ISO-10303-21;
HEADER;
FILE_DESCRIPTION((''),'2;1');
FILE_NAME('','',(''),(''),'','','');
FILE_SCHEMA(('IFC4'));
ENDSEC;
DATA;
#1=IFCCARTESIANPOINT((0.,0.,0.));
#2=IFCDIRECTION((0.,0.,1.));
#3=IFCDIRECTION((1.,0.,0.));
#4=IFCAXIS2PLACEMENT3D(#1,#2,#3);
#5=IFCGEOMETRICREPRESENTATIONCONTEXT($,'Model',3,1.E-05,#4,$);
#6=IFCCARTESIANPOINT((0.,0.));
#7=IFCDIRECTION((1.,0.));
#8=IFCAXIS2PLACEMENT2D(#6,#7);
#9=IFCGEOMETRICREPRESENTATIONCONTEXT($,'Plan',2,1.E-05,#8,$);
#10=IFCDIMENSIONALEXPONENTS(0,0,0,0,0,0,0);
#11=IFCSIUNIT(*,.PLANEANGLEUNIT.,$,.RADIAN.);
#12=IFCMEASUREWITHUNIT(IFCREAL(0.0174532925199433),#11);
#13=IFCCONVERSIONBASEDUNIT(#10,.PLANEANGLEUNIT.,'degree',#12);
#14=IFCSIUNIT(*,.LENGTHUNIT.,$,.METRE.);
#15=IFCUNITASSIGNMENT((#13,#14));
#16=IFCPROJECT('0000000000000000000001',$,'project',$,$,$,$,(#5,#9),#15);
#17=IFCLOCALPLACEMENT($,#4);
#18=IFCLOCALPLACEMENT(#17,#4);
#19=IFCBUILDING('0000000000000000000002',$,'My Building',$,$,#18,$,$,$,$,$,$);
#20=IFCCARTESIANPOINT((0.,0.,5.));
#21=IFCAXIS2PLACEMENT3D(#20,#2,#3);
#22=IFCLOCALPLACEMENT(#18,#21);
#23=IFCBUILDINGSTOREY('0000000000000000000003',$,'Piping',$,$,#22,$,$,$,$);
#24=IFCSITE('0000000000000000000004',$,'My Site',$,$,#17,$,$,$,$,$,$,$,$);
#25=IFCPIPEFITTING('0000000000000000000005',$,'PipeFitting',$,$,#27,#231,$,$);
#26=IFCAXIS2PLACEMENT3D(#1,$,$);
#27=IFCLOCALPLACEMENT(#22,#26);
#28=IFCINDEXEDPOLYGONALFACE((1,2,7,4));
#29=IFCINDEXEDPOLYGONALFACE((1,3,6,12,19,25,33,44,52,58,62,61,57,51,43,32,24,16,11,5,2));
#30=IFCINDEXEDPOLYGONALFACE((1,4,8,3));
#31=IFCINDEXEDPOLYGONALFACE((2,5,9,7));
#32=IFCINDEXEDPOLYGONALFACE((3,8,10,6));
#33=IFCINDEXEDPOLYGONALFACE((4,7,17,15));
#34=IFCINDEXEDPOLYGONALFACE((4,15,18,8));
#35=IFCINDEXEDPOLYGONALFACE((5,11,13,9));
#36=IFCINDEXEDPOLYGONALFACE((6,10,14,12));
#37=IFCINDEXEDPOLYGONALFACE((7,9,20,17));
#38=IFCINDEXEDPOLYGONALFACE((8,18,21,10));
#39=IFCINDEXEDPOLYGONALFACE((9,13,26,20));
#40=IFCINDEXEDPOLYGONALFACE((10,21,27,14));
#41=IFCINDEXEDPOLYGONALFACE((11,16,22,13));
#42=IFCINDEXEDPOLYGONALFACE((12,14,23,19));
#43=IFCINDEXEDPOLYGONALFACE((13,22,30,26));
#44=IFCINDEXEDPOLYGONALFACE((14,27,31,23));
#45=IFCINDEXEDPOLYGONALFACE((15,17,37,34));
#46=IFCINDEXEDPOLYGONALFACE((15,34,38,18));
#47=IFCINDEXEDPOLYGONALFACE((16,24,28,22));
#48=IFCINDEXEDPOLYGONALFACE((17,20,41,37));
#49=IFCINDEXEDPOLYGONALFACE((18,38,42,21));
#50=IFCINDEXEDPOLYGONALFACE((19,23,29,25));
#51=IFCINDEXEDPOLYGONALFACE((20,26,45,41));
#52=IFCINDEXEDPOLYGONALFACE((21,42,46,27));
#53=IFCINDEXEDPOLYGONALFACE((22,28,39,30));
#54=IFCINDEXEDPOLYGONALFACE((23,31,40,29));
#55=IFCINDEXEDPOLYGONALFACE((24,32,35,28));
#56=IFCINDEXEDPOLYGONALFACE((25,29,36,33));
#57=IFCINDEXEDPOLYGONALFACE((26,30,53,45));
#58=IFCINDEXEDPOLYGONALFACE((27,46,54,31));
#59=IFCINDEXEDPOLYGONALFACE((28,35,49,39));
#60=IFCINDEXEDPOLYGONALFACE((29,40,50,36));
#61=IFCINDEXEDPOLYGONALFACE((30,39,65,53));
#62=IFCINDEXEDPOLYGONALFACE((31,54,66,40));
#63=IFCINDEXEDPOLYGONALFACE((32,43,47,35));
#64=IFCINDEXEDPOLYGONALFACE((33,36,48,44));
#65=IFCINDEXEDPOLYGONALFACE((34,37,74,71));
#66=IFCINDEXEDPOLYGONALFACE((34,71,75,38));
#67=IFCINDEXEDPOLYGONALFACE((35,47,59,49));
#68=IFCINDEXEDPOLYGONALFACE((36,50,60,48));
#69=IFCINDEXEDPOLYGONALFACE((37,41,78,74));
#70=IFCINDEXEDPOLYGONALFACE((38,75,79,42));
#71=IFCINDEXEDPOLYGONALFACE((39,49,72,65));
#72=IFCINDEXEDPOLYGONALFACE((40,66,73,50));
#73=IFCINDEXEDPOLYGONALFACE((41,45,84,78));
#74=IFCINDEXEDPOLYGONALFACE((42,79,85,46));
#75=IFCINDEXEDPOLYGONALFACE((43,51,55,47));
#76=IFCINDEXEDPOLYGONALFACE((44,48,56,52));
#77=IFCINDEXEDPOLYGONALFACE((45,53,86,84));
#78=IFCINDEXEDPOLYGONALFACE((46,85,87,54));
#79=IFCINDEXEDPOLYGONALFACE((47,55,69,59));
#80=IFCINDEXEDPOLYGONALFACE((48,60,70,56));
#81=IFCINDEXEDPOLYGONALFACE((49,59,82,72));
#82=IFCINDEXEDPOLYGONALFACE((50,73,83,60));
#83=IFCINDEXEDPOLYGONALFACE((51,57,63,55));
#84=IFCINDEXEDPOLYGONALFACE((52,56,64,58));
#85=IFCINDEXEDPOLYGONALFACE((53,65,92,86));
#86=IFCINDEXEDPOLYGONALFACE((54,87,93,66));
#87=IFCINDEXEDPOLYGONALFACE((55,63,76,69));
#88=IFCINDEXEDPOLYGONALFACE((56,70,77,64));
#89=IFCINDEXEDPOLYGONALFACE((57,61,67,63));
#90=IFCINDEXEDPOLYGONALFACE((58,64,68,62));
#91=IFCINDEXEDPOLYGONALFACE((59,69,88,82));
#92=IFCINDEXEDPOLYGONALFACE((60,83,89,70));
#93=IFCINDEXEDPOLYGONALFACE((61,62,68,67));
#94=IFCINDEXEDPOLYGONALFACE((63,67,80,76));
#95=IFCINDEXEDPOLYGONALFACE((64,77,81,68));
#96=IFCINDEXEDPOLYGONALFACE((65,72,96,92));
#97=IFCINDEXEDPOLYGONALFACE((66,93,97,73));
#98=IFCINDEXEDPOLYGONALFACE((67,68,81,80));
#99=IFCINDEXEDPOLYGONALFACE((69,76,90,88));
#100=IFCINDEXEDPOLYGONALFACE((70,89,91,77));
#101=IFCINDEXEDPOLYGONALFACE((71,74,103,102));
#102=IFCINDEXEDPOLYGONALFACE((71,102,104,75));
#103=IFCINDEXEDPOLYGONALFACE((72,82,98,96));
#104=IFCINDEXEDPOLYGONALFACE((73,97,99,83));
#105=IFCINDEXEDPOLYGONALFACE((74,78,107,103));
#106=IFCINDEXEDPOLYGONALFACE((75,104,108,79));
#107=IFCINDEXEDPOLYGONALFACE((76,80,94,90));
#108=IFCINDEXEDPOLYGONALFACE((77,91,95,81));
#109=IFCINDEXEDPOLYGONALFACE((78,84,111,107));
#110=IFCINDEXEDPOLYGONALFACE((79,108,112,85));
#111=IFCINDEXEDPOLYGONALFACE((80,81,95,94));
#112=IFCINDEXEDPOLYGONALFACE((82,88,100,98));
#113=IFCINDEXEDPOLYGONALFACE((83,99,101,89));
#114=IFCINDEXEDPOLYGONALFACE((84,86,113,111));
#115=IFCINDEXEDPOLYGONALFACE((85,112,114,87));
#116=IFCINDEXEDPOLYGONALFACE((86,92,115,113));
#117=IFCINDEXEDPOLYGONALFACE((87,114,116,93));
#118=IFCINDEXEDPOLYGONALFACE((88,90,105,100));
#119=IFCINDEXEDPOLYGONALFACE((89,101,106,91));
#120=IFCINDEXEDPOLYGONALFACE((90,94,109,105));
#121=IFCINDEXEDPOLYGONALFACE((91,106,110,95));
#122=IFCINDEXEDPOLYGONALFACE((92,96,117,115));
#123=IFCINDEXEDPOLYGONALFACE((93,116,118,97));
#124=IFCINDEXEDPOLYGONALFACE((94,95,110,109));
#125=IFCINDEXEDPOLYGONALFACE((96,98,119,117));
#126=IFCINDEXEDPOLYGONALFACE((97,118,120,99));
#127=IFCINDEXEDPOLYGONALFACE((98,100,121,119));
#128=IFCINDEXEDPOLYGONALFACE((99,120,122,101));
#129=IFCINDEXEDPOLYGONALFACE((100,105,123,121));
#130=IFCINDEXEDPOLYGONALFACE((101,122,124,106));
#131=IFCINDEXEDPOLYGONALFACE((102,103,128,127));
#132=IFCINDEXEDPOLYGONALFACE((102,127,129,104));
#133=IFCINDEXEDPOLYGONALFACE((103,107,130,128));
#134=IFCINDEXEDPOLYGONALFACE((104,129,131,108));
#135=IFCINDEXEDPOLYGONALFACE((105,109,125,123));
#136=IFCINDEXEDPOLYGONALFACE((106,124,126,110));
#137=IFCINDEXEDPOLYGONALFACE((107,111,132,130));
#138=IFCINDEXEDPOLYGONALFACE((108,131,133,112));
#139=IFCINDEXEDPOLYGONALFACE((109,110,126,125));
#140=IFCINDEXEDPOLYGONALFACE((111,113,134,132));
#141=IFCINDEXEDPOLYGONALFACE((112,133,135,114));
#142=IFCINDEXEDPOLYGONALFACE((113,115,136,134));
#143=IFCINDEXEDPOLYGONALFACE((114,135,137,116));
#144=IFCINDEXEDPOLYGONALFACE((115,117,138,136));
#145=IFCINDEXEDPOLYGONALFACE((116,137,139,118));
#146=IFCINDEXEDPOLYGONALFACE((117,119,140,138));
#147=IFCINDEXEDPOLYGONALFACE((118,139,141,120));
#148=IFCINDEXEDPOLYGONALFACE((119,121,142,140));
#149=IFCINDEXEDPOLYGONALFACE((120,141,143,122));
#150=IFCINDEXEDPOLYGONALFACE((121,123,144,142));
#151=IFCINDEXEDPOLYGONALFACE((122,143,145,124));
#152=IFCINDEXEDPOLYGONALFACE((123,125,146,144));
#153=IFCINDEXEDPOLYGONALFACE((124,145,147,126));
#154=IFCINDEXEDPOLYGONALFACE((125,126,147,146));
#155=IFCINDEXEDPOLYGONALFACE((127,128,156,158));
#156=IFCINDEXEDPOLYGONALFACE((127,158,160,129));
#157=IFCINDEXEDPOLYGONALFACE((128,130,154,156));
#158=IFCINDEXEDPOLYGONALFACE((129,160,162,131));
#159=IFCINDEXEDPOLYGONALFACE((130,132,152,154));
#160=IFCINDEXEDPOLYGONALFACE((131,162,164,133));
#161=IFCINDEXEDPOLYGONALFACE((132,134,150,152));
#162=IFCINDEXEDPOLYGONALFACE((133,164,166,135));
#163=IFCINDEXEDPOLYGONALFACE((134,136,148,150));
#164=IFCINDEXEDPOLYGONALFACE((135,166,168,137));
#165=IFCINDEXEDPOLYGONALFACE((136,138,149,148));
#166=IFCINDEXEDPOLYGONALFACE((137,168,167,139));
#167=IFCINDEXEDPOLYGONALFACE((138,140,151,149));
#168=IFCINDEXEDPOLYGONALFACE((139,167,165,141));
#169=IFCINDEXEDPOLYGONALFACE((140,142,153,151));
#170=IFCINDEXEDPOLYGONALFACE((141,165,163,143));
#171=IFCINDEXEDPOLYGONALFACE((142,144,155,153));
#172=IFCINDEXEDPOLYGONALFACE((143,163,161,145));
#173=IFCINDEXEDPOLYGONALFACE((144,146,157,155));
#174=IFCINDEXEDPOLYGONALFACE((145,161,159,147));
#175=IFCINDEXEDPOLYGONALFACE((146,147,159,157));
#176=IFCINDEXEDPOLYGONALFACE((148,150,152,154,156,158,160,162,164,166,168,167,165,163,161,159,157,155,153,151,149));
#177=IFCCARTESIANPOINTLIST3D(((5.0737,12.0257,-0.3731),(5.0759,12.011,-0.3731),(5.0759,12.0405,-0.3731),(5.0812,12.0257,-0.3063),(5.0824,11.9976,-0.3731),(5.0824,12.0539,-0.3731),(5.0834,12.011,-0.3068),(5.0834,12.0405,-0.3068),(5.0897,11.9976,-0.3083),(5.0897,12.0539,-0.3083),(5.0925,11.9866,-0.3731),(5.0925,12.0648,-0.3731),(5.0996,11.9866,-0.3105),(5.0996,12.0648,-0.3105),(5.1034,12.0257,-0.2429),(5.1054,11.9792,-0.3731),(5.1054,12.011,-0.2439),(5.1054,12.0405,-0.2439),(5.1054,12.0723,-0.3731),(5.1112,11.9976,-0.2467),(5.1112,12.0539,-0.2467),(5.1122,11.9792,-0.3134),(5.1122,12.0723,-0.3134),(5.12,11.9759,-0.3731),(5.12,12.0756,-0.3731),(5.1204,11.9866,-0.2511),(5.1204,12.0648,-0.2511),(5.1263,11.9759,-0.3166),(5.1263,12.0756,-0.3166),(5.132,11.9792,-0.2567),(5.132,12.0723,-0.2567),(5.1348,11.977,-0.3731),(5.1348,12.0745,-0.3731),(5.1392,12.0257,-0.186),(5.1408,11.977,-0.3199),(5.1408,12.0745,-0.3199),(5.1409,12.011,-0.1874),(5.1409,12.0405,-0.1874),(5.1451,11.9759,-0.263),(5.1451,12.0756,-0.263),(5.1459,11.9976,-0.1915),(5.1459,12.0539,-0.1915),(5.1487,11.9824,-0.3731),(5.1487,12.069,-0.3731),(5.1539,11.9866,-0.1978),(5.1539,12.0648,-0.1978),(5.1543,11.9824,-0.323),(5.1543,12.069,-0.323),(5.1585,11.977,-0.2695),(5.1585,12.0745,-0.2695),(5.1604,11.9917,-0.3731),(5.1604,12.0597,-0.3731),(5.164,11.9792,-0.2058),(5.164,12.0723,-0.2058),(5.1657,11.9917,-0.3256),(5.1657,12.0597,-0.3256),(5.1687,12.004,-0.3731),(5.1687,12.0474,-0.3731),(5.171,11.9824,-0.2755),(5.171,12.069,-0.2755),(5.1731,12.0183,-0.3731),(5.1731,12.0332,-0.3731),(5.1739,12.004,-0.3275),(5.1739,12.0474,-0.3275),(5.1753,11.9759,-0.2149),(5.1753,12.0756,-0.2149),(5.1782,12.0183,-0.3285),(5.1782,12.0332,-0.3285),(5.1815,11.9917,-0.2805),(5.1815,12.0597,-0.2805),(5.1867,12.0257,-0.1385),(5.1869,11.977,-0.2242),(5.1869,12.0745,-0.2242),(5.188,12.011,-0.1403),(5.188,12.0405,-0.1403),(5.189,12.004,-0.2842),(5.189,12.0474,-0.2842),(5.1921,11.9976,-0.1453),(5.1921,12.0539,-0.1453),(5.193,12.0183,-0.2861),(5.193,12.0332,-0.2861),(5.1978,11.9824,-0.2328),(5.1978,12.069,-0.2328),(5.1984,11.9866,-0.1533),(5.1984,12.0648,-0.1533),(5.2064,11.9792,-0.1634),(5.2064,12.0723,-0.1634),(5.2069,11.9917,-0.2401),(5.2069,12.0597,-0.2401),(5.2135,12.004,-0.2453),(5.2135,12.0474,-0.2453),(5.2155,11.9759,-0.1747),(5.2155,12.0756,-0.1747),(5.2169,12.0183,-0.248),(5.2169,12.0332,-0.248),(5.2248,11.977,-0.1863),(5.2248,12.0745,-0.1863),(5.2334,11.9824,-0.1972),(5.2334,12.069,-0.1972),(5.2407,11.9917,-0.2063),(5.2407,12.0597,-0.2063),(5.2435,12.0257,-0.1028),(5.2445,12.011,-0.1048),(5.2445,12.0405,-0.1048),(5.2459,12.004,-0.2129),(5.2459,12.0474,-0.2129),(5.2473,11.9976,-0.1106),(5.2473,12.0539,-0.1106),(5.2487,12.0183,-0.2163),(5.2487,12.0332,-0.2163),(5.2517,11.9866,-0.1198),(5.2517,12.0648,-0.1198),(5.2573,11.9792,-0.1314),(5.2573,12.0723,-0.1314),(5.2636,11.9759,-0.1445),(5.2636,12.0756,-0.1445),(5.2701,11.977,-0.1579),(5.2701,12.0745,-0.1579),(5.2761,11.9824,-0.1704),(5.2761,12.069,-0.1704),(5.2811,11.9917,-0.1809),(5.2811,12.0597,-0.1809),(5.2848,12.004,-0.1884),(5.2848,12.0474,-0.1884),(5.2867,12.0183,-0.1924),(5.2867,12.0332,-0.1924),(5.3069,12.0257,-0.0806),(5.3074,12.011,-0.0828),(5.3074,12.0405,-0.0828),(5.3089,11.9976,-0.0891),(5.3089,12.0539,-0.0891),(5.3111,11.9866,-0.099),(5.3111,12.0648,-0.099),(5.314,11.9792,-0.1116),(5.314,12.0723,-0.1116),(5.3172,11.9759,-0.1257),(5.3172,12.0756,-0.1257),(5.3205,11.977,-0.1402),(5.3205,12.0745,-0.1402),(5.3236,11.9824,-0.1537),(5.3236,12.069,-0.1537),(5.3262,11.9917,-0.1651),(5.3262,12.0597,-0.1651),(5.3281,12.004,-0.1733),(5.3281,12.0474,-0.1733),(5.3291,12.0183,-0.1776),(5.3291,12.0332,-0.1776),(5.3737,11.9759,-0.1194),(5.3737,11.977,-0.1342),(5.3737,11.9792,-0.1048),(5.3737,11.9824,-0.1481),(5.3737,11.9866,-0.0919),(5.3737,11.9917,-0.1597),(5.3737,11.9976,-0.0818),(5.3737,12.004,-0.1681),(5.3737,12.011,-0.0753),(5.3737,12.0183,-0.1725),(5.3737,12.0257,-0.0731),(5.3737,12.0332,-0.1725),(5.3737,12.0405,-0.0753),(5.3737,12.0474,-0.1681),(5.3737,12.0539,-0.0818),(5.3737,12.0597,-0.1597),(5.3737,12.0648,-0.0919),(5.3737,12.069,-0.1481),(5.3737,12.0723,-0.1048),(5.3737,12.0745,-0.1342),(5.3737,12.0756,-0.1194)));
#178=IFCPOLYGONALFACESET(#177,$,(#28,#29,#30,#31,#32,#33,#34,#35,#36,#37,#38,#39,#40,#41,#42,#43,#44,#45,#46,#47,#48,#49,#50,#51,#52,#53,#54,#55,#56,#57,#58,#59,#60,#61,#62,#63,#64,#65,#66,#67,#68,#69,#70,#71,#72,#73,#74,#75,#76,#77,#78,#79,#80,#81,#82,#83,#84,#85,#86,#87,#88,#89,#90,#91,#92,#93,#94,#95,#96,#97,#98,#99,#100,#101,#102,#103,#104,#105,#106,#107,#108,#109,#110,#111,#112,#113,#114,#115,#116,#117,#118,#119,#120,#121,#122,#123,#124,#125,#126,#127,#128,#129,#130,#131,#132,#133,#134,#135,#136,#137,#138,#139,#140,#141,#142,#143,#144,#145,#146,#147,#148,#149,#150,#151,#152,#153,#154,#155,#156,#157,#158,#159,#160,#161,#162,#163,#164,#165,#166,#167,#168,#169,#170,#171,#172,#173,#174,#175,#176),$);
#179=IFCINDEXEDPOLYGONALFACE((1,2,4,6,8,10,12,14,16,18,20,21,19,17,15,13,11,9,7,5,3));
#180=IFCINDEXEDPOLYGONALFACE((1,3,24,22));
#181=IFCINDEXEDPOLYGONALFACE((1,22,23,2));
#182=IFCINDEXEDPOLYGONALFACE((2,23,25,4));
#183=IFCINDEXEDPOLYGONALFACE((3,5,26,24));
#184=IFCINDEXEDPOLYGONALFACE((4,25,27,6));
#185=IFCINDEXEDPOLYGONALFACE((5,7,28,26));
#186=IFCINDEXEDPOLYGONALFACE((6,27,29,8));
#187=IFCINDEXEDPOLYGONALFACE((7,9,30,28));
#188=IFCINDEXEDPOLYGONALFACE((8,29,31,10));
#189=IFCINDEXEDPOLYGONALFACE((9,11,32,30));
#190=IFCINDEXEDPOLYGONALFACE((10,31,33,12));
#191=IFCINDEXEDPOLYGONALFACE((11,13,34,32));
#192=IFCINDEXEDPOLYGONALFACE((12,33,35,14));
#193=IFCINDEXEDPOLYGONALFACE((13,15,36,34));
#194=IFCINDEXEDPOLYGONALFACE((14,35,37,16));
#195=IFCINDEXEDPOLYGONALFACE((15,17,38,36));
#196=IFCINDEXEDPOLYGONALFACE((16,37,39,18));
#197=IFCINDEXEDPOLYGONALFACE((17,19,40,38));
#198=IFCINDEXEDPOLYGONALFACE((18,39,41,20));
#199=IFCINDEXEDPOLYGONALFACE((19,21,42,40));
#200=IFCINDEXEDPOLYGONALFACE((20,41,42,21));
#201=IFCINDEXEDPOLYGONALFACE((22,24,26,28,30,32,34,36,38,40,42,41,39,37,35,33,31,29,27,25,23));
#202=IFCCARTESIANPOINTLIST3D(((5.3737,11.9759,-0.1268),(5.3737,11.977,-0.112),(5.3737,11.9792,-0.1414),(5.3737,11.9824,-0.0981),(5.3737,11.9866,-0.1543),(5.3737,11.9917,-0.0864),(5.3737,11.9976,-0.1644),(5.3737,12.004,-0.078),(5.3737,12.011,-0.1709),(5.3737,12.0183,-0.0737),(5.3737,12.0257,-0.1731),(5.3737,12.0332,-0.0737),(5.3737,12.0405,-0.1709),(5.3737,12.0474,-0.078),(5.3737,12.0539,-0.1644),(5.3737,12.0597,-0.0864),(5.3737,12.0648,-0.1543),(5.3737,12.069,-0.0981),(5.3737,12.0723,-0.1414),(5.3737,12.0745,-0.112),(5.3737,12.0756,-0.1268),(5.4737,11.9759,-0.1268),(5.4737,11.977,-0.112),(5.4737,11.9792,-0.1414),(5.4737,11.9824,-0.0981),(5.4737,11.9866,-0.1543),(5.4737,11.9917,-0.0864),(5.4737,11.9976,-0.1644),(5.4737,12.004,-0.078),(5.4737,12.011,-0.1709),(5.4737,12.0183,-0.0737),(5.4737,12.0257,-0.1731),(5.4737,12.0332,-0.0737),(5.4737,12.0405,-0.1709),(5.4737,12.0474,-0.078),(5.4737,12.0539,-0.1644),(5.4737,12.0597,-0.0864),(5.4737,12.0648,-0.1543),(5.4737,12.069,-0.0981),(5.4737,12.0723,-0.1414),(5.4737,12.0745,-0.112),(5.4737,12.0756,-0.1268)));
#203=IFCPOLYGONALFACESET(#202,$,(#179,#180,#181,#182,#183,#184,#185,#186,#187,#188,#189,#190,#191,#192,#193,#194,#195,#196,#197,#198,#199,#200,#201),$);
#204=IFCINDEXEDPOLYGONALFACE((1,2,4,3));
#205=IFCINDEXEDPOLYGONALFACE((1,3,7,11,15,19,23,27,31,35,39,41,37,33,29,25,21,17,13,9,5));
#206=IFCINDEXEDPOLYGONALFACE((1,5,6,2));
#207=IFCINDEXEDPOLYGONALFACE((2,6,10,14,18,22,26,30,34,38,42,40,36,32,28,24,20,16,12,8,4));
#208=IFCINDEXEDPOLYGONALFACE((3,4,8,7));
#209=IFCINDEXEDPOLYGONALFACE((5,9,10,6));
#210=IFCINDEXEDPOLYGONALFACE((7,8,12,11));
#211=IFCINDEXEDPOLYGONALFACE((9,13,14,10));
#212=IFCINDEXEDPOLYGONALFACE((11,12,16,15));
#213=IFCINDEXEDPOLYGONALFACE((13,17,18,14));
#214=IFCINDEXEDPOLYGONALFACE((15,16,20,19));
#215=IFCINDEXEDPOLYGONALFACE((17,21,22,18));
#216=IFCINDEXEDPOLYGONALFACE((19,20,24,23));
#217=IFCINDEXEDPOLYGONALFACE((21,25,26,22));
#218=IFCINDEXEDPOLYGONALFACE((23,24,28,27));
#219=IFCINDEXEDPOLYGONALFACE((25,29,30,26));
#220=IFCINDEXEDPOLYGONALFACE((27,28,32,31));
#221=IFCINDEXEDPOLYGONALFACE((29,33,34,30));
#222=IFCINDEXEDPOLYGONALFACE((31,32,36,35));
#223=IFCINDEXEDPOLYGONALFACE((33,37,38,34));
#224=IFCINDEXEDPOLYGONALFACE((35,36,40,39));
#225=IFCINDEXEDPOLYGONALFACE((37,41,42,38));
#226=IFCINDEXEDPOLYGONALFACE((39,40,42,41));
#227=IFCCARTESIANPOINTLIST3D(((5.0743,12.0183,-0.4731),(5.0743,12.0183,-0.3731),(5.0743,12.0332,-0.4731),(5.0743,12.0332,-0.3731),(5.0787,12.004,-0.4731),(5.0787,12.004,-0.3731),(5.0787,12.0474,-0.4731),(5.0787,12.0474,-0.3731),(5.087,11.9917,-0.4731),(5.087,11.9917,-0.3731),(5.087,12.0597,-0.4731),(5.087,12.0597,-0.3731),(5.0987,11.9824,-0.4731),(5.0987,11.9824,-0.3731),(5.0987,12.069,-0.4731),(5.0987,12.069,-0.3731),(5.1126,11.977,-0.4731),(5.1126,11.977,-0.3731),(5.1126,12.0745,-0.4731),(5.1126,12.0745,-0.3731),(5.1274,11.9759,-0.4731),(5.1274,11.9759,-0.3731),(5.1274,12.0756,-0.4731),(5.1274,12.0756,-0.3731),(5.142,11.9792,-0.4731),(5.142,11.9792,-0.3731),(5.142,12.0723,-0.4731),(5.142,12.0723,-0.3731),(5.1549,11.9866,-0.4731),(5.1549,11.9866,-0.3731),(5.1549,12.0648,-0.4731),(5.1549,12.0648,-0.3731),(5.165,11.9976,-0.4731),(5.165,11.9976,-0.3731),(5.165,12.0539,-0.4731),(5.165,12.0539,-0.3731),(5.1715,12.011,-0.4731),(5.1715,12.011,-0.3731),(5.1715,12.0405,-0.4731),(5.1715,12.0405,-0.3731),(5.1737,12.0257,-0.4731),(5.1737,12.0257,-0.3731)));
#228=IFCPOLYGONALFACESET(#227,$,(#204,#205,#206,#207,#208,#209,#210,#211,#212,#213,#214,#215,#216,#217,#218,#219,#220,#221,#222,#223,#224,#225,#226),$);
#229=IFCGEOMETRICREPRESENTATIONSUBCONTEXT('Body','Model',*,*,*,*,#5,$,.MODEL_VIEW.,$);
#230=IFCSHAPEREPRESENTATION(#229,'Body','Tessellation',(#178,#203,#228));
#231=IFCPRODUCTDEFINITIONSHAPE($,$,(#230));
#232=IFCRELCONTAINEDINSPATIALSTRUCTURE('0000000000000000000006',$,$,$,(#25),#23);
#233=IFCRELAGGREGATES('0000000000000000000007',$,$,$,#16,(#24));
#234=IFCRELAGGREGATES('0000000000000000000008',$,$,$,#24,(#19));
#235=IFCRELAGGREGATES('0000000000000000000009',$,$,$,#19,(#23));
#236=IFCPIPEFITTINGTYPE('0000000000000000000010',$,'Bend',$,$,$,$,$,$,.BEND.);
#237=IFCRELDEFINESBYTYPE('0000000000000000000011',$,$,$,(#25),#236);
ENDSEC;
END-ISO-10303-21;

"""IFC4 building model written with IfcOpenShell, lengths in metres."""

from ifc_helpers import new_model, entity, si_unit, converted_unit, frame, origin_with_axes, origin_2d_with_axis, place, context, subcontext, project, spatial, circle, extrude, source, transform, mapped, type_object, type_shapes, element, save


model = new_model("IFC4")

# Units and contexts
model_context = context("Model", 3, precision=1e-05, world=origin_with_axes())
plan_context = context("Plan", 2, precision=1e-05, world=origin_2d_with_axis())
body_context = subcontext(model_context, "Body", "Model", "MODEL_VIEW")
ifc_project = project(units=[converted_unit("PLANEANGLEUNIT", "degree", entity("IfcReal", 0.0174532925199433), si_unit("PLANEANGLEUNIT", "RADIAN"), dimensions=[0, 0, 0, 0, 0, 0, 0]), si_unit("LENGTHUNIT", "METRE")], contexts=[model_context, plan_context])

# Site, building, storey
site_placement = place(None, origin_with_axes())
site = spatial("IfcSite", under=ifc_project, at=site_placement, Name="My Site")
building_placement = place(site_placement, origin_with_axes())
building = spatial("IfcBuilding", under=site, at=building_placement, Name="My Building")
storey_placement = place(building_placement, frame((0.0, 0.0, 5.0), z_axis=(0.0, 0.0, 1.0), x_axis=(1.0, 0.0, 0.0)))
storey = spatial("IfcBuildingStorey", under=building, at=storey_placement, Name="Piping")

# Pipe fitting
pipe_fitting_type_1 = type_object("IfcPipeFittingType", Name="Bend", PredefinedType="BEND")
shared_shape = source(origin_with_axes(), body_context, "Body", "SolidModel", [
    entity("IfcSweptDiskSolid", entity("IfcIndexedPolyCurve", entity("IfcCartesianPointList3D", [[0.0, 0.0, -0.1], [0.0732, 0.0, -0.2768], [0.25, 0.0, -0.35]]), [entity("IfcArcIndex", [1, 2, 3])]), 0.05),
    extrude(circle(Radius=0.05), origin_with_axes(), (0.0, 0.0, -1.0), 0.1),
    extrude(circle(Radius=0.05), frame((0.25, 0.0, -0.35), z_axis=(1.0, 0.0, 0.0), x_axis=(0.0, 0.0, 1.0)), (0.0, 0.0, 1.0), 0.1),
])
type_shapes(pipe_fitting_type_1, [shared_shape])
for number, where, z_axis, x_axis, name in (
    (1, (5.4737, 12.0257, -0.1231), (1.0, 0.000001, 0.0), (0.0, 0.0, -1.0), "PipeFitting"),
):
    element("IfcPipeFitting", number, at=place(storey_placement, frame(where, z_axis=z_axis, x_axis=x_axis)), inside=storey, type_object=pipe_fitting_type_1, Name=name, context=body_context, shape_type="MappedRepresentation", body=[
        mapped(shared_shape, transform((0.0, 0.0, 0.0), x_axis=(1.0, 0.0, 0.0), y_axis=(0.0, 1.0, 0.0), z_axis=(0.0, 0.0, 1.0), scale=1.0)),
    ])

save(model, "model.ifc")
